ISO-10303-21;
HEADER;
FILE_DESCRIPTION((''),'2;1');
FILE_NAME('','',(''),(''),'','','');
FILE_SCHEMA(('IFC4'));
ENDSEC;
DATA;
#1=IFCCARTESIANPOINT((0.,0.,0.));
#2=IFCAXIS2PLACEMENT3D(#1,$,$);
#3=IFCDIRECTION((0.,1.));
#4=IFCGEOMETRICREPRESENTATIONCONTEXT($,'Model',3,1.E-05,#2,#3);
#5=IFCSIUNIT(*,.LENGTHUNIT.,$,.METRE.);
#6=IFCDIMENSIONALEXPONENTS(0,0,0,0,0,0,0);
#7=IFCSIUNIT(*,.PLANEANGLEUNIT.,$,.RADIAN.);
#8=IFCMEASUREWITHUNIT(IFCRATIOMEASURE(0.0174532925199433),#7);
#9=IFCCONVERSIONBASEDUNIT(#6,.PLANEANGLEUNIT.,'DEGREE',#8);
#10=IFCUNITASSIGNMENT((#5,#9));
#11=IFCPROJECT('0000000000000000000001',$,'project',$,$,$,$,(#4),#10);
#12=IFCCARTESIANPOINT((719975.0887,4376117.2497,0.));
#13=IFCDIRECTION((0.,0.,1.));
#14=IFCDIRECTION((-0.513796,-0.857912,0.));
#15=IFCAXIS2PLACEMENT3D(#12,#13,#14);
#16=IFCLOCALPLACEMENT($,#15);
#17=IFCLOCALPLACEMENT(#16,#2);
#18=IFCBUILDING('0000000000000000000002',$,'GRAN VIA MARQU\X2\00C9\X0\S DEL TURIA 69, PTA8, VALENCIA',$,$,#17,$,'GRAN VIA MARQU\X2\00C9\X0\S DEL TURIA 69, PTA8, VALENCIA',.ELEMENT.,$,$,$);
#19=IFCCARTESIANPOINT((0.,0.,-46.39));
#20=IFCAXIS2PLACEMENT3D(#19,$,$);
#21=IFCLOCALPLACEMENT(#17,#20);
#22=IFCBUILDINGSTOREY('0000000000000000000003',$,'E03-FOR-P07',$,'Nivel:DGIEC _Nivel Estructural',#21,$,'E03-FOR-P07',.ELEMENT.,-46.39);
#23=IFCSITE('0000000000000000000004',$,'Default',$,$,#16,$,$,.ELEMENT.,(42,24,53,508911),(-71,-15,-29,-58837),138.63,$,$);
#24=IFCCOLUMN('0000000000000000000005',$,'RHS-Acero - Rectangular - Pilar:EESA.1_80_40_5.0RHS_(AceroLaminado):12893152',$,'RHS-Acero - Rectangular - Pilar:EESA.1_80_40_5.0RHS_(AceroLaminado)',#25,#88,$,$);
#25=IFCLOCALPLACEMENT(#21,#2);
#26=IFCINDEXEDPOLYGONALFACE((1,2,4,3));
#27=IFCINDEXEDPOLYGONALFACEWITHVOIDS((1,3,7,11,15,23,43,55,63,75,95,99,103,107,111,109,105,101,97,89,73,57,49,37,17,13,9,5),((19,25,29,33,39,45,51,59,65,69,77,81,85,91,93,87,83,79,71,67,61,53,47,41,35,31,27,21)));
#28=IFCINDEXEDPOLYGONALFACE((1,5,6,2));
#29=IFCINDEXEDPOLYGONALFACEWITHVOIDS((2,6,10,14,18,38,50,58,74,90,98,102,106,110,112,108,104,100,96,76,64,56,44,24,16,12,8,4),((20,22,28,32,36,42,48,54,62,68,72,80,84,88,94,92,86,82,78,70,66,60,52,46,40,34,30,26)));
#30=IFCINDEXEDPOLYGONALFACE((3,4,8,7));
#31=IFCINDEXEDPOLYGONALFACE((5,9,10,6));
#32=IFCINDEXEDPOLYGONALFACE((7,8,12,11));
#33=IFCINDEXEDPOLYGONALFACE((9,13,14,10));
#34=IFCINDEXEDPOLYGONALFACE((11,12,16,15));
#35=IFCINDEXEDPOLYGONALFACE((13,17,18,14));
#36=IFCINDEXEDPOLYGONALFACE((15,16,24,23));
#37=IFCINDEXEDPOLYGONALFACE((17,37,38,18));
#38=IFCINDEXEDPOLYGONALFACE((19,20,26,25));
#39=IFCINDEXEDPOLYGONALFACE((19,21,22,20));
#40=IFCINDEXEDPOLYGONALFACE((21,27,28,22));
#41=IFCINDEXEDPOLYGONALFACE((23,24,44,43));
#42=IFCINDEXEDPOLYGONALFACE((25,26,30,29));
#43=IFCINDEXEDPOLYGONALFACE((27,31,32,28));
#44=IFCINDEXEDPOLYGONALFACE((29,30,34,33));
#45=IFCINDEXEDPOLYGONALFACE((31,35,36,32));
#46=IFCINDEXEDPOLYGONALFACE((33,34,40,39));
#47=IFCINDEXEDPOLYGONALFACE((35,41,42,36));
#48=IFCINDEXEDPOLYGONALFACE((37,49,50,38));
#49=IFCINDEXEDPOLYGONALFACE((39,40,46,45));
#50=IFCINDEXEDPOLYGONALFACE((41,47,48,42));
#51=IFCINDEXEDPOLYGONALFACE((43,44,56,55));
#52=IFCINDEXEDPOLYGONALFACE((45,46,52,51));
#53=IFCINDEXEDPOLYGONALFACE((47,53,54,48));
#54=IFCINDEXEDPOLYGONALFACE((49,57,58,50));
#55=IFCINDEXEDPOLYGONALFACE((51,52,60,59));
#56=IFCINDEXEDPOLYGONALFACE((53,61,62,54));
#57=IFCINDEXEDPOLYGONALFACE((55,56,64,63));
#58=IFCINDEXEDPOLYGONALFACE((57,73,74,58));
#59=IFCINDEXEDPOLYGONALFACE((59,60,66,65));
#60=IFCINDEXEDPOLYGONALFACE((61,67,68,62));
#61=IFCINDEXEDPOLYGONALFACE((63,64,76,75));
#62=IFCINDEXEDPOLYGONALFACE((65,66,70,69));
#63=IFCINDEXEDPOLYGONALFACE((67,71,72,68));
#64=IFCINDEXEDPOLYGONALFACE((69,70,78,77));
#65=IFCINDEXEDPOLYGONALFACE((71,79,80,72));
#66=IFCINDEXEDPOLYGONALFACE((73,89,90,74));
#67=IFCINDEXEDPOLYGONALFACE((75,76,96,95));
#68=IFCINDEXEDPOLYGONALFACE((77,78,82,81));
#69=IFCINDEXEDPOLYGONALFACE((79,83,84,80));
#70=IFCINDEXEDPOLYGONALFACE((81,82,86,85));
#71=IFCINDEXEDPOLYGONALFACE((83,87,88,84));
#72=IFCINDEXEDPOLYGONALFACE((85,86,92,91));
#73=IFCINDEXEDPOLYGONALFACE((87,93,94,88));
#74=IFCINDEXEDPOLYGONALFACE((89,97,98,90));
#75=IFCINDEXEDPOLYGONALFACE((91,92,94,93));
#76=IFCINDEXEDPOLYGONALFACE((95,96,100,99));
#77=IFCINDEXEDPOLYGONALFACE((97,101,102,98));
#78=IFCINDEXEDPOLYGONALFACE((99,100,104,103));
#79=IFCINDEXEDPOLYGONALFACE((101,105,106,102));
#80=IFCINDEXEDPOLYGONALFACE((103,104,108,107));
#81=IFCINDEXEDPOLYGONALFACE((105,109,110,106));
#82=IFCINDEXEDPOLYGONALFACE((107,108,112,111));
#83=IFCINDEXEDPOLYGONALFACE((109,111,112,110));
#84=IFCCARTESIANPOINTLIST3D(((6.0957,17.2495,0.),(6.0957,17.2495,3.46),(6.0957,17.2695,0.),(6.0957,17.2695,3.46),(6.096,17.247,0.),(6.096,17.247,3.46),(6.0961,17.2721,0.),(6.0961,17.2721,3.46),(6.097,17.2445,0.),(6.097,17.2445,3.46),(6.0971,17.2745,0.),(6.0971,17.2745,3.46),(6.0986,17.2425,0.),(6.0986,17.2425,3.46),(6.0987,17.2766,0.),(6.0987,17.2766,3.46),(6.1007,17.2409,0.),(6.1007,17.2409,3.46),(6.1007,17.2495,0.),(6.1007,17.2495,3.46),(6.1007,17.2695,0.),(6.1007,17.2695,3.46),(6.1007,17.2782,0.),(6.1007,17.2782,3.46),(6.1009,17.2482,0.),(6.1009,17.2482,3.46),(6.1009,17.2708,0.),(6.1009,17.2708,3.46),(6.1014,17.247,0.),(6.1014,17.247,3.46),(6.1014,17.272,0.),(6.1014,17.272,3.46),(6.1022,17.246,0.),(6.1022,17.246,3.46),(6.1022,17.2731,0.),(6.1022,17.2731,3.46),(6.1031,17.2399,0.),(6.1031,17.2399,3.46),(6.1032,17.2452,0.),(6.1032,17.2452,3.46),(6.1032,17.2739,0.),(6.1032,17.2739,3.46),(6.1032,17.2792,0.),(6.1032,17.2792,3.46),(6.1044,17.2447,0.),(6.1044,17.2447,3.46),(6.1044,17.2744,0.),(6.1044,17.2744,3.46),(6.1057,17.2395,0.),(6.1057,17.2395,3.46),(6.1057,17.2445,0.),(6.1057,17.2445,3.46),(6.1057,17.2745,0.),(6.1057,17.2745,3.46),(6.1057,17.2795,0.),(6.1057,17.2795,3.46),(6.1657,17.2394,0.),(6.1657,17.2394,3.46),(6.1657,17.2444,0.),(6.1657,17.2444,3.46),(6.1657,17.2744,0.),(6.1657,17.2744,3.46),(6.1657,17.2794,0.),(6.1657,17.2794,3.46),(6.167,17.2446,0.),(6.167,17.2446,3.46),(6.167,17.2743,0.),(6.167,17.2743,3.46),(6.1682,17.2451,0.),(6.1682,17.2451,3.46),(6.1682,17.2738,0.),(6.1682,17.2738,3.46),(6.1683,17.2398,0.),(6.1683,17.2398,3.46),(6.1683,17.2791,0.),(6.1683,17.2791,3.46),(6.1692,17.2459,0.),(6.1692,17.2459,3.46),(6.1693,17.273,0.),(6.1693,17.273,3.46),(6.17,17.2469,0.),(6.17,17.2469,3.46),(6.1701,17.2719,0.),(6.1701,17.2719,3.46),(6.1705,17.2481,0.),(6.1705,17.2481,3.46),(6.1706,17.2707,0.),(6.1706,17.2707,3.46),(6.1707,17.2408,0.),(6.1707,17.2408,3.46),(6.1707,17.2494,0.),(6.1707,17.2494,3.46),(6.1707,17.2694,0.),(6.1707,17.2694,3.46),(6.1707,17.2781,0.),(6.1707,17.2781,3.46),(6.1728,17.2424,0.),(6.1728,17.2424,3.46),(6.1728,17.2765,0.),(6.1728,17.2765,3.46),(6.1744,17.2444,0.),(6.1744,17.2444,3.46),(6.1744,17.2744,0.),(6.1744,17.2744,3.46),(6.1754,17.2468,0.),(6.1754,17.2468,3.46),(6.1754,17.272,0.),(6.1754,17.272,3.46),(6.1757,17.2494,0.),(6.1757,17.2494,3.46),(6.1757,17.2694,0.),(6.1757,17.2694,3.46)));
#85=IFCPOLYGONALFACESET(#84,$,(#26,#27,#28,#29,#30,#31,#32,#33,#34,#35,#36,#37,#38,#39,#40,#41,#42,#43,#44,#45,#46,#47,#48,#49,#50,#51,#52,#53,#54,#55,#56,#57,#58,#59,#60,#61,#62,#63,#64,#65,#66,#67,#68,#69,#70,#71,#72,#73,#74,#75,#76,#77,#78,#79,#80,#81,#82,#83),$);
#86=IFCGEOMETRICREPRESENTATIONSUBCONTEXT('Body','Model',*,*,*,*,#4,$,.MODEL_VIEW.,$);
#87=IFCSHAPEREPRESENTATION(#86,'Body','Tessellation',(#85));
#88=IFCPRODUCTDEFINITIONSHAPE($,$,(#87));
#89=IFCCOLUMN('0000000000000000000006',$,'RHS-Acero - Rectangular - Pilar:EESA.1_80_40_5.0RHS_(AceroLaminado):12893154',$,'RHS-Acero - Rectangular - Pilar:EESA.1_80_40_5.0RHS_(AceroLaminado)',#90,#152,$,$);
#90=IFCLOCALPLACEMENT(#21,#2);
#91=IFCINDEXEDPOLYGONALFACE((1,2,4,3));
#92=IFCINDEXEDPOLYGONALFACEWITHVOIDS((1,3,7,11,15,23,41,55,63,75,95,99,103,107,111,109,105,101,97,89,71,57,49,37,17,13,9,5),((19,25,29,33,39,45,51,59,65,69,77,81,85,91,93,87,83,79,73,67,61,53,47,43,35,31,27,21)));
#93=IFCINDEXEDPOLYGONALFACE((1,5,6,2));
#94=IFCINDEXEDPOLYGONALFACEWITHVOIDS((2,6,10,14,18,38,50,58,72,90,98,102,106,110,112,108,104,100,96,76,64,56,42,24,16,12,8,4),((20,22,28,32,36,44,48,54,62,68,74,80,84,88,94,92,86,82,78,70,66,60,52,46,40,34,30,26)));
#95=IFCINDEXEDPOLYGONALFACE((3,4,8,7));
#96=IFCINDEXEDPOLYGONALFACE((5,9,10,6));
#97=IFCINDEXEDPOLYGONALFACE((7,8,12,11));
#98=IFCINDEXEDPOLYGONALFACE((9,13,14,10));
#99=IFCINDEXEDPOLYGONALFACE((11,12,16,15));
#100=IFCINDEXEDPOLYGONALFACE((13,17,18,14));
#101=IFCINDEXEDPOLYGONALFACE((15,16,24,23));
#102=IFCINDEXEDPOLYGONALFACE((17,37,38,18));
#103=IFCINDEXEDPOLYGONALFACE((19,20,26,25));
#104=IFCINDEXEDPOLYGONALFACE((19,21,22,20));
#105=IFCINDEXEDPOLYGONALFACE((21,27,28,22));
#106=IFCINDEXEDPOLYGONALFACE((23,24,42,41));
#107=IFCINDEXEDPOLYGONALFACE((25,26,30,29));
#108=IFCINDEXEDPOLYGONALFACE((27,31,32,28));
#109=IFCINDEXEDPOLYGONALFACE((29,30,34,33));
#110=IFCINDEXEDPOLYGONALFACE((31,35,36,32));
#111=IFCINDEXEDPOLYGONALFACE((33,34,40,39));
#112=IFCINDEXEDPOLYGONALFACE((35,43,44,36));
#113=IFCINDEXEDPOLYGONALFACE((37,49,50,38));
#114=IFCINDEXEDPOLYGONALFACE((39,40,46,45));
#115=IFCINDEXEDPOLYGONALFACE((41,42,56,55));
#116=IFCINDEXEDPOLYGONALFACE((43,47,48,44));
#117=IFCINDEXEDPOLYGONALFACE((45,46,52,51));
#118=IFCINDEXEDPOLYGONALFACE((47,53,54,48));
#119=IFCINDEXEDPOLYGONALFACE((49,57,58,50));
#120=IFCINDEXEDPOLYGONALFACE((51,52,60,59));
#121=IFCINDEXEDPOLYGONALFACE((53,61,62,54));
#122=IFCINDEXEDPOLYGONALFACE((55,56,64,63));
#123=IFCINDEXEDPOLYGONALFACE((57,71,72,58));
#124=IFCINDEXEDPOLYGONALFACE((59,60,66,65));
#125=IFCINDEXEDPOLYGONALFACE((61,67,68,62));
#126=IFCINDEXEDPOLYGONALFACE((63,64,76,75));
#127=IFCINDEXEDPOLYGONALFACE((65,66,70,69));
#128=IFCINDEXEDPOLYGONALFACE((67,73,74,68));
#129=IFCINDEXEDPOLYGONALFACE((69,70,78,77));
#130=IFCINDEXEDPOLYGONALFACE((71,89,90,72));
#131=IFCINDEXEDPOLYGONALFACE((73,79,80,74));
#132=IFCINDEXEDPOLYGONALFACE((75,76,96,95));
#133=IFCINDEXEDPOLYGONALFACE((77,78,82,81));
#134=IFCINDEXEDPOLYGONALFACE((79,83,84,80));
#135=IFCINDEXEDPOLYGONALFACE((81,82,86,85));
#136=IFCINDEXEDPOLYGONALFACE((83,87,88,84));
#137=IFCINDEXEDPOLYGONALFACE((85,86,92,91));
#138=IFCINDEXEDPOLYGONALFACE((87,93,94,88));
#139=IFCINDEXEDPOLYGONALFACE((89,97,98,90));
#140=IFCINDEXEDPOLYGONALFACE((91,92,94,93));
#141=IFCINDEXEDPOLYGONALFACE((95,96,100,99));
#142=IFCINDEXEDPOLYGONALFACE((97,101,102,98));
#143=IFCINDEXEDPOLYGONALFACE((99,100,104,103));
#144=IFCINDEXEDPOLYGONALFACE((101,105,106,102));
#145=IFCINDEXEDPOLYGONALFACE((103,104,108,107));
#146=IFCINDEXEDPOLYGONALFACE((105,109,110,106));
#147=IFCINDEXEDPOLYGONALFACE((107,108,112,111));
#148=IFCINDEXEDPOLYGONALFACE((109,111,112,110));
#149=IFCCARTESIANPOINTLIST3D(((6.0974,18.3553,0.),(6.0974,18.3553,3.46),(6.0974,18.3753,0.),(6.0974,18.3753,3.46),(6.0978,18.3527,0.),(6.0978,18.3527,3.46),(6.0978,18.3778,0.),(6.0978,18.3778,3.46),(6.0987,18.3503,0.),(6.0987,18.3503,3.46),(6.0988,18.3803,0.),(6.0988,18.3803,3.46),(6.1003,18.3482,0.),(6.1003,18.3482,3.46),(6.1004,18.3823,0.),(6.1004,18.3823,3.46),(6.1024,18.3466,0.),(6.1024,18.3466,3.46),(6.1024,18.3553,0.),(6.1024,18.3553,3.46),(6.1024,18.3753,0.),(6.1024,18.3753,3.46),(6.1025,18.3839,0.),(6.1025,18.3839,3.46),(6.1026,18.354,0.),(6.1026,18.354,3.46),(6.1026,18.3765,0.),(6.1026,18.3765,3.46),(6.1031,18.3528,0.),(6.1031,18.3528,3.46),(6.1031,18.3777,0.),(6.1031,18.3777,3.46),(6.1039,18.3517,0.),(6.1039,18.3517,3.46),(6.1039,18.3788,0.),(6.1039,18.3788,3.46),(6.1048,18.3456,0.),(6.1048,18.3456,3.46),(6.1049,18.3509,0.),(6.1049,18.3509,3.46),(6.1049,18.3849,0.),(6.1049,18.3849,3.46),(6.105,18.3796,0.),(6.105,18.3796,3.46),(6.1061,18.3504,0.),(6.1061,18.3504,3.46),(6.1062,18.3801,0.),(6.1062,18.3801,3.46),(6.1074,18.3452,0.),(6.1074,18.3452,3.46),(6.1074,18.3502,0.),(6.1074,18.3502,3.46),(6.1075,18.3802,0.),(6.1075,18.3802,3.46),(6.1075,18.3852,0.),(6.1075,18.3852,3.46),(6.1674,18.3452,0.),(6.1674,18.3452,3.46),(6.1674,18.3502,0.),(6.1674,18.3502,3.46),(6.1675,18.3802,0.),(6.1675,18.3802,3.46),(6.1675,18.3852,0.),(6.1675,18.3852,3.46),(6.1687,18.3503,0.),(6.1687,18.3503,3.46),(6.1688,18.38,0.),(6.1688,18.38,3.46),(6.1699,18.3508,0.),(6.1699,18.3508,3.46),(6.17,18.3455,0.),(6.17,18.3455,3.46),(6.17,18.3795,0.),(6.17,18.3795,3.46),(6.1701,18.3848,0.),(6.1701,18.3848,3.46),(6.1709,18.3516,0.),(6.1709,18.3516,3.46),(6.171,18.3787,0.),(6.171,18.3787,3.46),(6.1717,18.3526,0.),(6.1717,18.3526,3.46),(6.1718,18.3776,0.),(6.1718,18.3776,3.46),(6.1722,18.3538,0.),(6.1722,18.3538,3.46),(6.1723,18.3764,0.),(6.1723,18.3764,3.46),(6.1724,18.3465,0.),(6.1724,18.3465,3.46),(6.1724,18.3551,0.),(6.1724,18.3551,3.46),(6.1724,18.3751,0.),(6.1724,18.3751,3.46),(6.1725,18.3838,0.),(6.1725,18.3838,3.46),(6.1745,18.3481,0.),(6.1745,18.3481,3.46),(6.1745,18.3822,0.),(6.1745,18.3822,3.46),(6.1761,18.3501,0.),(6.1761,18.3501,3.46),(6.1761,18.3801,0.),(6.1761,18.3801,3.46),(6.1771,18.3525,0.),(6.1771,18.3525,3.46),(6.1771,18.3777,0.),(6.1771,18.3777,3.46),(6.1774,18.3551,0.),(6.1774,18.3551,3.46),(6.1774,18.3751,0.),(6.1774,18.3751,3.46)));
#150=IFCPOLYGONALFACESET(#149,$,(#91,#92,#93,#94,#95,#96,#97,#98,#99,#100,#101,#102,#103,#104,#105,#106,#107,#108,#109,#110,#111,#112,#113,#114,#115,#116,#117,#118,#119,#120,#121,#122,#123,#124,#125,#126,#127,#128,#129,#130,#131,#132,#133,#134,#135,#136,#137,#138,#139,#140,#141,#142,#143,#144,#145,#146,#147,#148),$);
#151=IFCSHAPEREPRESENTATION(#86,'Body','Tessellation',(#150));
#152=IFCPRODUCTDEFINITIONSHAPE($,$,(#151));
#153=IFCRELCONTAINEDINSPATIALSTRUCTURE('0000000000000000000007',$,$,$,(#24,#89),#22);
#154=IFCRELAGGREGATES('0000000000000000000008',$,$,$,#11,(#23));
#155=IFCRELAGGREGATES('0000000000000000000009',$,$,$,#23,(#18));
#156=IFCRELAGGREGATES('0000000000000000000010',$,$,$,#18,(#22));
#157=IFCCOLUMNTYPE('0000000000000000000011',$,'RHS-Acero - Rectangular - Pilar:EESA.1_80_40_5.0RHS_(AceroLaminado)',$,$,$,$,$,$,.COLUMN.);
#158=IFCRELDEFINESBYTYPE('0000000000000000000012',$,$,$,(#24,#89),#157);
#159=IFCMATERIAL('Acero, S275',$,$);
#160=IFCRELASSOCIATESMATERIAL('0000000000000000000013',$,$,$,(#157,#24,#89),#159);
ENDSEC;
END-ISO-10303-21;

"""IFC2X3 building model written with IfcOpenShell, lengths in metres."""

from ifc_helpers import new_model, entity, si_unit, converted_unit, direction, frame, frame_2d, origin, place, context, subcontext, project, spatial, polyline, circle_curve, parameter, trimmed, segment, composite_curve, outline, extrude, source, transform, mapped, material, type_object, type_shapes, element, save


model = new_model("IFC2X3")

# Units and contexts
model_context = context("Model", 3, precision=1e-05, world=origin(), true_north=direction((0.0, 1.0)))
body_context = subcontext(model_context, "Body", "Model", "MODEL_VIEW")
ifc_project = project(units=[si_unit("LENGTHUNIT", "METRE"), converted_unit("PLANEANGLEUNIT", "DEGREE", entity("IfcRatioMeasure", 0.0174532925199433), si_unit("PLANEANGLEUNIT", "RADIAN"), dimensions=[0, 0, 0, 0, 0, 0, 0])], contexts=[model_context])

# Site, building, storey
site_placement = place(None, frame((719975.0887, 4376117.2497, 0.0), z_axis=(0.0, 0.0, 1.0), x_axis=(-0.513796, -0.857912, 0.0)))
site = spatial("IfcSite", under=ifc_project, at=site_placement, Name="Default", CompositionType="ELEMENT", RefLatitude=(42, 24, 53, 508911), RefLongitude=(-71, -15, -29, -58837), RefElevation=138.63)
building_placement = place(site_placement, origin())
building = spatial("IfcBuilding", under=site, at=building_placement, Name="GRAN VIA MARQUÉS DEL TURIA 69, PTA8, VALENCIA", LongName="GRAN VIA MARQUÉS DEL TURIA 69, PTA8, VALENCIA", CompositionType="ELEMENT")
storey_placement = place(building_placement, frame((0.0, 0.0, -46.39)))
storey = spatial("IfcBuildingStorey", under=building, at=storey_placement, Name="E03-FOR-P07", ObjectType="Nivel:DGIEC _Nivel Estructural", LongName="E03-FOR-P07", CompositionType="ELEMENT", Elevation=-46.39)

# Columns
ifc_material = material(Name="Acero, S275")
column_type_1 = type_object("IfcColumnType", Name="RHS-Acero - Rectangular - Pilar:EESA.1_80_40_5.0RHS_(AceroLaminado)", PredefinedType="COLUMN", material=ifc_material)
shared_shape_1 = source(origin(), body_context, "Body", "SweptSolid", [
    extrude(outline(composite_curve([segment(polyline([(-0.01, -0.04), (0.01, -0.04)]), True, "CONTINUOUS"), segment(trimmed(circle_curve(frame_2d((0.01, -0.03), x_axis=(-1.0, 0.0)), 0.01), [parameter(90.0)], [parameter(180.0)], True, "PARAMETER"), True, "CONTINUOUS"), segment(polyline([(0.02, -0.03), (0.02, 0.03)]), True, "CONTINUOUS"), segment(trimmed(circle_curve(frame_2d((0.01, 0.03), x_axis=(-1.0, 0.0)), 0.01), [parameter(180.0)], [parameter(270.0)], True, "PARAMETER"), True, "CONTINUOUS"), segment(polyline([(0.01, 0.04), (-0.01, 0.04)]), True, "CONTINUOUS"), segment(trimmed(circle_curve(frame_2d((-0.01, 0.03), x_axis=(-1.0, 0.0)), 0.01), [parameter(270.0)], [parameter(360.0)], True, "PARAMETER"), True, "CONTINUOUS"), segment(polyline([(-0.02, 0.03), (-0.02, -0.03)]), True, "CONTINUOUS"), segment(trimmed(circle_curve(frame_2d((-0.01, -0.03), x_axis=(-1.0, 0.0)), 0.01), [parameter(360.0)], [parameter(90.0)], True, "PARAMETER"), True, "CONTINUOUS")], self_intersect=False), holes=[composite_curve([segment(trimmed(circle_curve(frame_2d((-0.01, -0.03), x_axis=(-1.0, 0.0)), 0.005), [parameter(0.0)], [parameter(90.0)], True, "PARAMETER"), False, "CONTINUOUS"), segment(polyline([(-0.015, -0.03), (-0.015, 0.03)]), True, "CONTINUOUS"), segment(trimmed(circle_curve(frame_2d((-0.01, 0.03), x_axis=(-1.0, 0.0)), 0.005), [parameter(270.0)], [parameter(0.0)], True, "PARAMETER"), False, "CONTINUOUS"), segment(polyline([(-0.01, 0.035), (0.01, 0.035)]), True, "CONTINUOUS"), segment(trimmed(circle_curve(frame_2d((0.01, 0.03), x_axis=(-1.0, 0.0)), 0.005), [parameter(180.0)], [parameter(270.0)], True, "PARAMETER"), False, "CONTINUOUS"), segment(polyline([(0.015, 0.03), (0.015, -0.03)]), True, "CONTINUOUS"), segment(trimmed(circle_curve(frame_2d((0.01, -0.03), x_axis=(-1.0, 0.0)), 0.005), [parameter(90.0)], [parameter(180.0)], True, "PARAMETER"), False, "CONTINUOUS"), segment(polyline([(0.01, -0.035), (-0.01, -0.035)]), True, "CONTINUOUS")], self_intersect=False)]), frame((0.0, 0.0, -46.39), z_axis=(0.0, 0.0, 1.0), x_axis=(-1.0, 0.0, 0.0)), (0.0, 0.0, 1.0), 3.46),
])
type_shapes(column_type_1, [shared_shape_1])
for number, where, z_axis, x_axis, name in (
    (1, (6.1357, 17.2595, 46.39), (0.0, 0.0, 1.0), (0.001552, 0.999999, 0.0), "RHS-Acero - Rectangular - Pilar:EESA.1_80_40_5.0RHS_(AceroLaminado):12893152"),
    (2, (6.1374, 18.3652, 46.39), (0.0, 0.0, 1.0), (0.001552, 0.999999, 0.0), "RHS-Acero - Rectangular - Pilar:EESA.1_80_40_5.0RHS_(AceroLaminado):12893154"),
):
    element("IfcColumn", number, at=place(storey_placement, frame(where, z_axis=z_axis, x_axis=x_axis)), inside=storey, type_object=column_type_1, material=ifc_material, Name=name, ObjectType="RHS-Acero - Rectangular - Pilar:EESA.1_80_40_5.0RHS_(AceroLaminado)", context=body_context, shape_type="MappedRepresentation", body=[
        mapped(shared_shape_1, transform((0.0, 0.0, 0.0), scale=1.0)),
    ])

save(model, "model.ifc")
